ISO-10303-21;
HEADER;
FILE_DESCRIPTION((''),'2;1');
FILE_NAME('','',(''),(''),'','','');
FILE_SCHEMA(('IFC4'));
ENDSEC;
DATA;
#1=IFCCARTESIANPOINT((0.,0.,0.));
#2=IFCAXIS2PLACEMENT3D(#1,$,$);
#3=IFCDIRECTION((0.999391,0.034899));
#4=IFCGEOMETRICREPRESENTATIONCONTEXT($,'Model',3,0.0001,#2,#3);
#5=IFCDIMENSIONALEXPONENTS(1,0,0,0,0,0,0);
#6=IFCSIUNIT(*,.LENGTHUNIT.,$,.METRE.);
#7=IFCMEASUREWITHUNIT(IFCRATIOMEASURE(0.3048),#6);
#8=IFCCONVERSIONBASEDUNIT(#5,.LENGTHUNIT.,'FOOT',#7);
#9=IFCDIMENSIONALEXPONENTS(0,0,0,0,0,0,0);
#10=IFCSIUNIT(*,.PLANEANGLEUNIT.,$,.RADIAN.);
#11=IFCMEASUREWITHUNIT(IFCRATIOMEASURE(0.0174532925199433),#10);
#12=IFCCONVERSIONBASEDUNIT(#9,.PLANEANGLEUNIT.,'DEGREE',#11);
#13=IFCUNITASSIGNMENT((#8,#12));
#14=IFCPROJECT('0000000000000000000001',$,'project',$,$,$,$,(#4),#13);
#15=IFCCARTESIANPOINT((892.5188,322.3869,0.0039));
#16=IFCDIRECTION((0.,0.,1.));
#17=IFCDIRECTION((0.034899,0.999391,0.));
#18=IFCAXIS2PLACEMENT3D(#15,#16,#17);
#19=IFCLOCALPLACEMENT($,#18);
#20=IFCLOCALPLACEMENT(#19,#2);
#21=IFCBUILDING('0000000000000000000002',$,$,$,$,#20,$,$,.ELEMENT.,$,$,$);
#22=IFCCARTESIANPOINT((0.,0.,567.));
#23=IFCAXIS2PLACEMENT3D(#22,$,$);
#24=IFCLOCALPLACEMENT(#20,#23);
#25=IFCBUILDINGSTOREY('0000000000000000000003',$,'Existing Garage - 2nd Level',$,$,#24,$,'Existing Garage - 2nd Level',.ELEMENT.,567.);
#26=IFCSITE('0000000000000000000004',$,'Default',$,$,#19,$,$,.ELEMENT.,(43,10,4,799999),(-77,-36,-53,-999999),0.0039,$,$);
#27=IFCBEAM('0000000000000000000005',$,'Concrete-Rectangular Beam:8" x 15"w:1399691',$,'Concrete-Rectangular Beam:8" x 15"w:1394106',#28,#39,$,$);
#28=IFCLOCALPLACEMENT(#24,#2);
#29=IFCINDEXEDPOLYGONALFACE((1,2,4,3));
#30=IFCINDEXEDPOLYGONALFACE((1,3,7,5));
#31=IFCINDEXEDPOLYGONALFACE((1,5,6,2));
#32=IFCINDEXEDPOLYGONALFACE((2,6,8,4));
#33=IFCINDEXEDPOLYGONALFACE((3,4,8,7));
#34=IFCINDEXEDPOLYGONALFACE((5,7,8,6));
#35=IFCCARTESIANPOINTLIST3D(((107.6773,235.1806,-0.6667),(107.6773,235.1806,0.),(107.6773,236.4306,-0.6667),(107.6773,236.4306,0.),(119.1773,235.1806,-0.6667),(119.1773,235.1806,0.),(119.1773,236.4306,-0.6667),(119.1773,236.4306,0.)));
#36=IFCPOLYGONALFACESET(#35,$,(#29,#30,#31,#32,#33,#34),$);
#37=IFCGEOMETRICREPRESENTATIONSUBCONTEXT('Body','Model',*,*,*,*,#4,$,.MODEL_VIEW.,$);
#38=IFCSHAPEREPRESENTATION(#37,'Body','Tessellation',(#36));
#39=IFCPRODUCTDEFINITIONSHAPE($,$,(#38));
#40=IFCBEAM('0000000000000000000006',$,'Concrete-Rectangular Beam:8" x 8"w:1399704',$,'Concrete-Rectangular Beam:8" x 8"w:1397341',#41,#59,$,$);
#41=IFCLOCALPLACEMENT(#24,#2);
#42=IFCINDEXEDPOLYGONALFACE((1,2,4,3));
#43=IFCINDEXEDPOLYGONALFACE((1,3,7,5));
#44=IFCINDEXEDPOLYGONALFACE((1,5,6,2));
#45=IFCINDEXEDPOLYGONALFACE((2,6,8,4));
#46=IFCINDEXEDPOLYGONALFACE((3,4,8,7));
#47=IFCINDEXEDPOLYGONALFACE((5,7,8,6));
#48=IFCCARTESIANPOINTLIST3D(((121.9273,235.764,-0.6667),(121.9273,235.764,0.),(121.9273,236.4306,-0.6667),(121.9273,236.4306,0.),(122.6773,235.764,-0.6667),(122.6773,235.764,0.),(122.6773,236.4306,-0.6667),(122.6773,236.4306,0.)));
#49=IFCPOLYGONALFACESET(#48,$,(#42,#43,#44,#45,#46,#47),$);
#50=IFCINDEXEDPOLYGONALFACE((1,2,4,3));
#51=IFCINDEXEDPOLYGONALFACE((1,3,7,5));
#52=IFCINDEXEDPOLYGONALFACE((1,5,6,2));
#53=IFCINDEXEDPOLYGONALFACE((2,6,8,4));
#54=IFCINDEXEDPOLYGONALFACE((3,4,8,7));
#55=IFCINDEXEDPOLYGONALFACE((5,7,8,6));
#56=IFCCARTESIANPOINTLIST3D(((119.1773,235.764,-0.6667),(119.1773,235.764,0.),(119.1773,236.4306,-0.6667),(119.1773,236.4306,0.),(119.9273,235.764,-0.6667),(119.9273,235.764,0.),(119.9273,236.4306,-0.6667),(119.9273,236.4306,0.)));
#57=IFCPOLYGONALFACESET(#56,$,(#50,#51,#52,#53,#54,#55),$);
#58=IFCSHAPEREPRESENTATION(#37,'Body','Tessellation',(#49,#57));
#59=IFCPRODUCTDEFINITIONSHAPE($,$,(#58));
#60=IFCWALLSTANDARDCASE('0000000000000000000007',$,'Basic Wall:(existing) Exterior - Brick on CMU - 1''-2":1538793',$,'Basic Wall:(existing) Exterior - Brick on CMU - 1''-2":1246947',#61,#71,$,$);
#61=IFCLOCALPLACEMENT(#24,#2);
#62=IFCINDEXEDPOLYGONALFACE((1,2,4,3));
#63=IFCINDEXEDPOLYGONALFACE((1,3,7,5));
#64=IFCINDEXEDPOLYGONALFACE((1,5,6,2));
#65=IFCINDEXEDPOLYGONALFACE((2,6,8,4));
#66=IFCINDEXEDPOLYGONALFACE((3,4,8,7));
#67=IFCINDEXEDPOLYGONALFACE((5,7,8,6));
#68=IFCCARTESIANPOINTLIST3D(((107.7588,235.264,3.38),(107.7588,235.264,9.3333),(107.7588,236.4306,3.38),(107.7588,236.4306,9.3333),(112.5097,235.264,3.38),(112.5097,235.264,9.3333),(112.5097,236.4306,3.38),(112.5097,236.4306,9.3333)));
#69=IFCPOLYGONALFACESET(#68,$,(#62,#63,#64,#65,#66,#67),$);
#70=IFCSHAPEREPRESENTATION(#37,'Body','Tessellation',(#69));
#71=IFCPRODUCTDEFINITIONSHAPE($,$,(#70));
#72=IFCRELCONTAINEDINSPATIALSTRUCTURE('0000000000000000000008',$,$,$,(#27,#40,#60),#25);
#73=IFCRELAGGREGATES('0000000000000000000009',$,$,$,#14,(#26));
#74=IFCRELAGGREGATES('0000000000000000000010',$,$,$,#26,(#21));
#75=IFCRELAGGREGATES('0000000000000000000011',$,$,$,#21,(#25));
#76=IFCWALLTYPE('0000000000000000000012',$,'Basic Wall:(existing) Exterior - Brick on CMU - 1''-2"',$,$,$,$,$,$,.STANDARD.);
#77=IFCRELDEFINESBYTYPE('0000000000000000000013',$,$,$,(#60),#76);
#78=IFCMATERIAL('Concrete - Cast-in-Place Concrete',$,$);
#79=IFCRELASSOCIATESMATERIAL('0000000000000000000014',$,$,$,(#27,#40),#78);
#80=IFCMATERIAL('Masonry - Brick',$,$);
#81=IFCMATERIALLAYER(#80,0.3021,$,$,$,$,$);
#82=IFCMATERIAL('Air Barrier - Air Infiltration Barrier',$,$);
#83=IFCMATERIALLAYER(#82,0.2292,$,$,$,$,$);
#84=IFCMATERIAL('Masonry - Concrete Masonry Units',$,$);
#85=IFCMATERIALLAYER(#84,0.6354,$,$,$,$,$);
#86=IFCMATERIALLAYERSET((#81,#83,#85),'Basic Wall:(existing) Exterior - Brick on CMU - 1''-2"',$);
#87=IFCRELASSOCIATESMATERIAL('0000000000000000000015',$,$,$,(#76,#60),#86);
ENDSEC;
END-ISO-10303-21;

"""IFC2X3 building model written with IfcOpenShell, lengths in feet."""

from ifc_helpers import new_model, entity, si_unit, converted_unit, direction, frame, frame_2d, origin, place, context, subcontext, project, spatial, rectangle, extrude, material, layer, layer_set, layer_usage, type_object, element, save


model = new_model("IFC2X3")

# Units and contexts
model_context = context("Model", 3, precision=0.0001, world=origin(), true_north=direction((0.999391, 0.034899)))
body_context = subcontext(model_context, "Body", "Model", "MODEL_VIEW")
ifc_project = project(units=[converted_unit("LENGTHUNIT", "FOOT", entity("IfcRatioMeasure", 0.3048), si_unit("LENGTHUNIT", "METRE"), dimensions=[1, 0, 0, 0, 0, 0, 0]), converted_unit("PLANEANGLEUNIT", "DEGREE", entity("IfcRatioMeasure", 0.0174532925199433), si_unit("PLANEANGLEUNIT", "RADIAN"), dimensions=[0, 0, 0, 0, 0, 0, 0])], contexts=[model_context])

# Site, building, storey
site_placement = place(None, frame((892.5188, 322.3869, 0.0039), z_axis=(0.0, 0.0, 1.0), x_axis=(0.034899, 0.999391, 0.0)))
site = spatial("IfcSite", under=ifc_project, at=site_placement, Name="Default", CompositionType="ELEMENT", RefLatitude=(43, 10, 4, 799999), RefLongitude=(-77, -36, -53, -999999), RefElevation=0.0039)
building_placement = place(site_placement, origin())
building = spatial("IfcBuilding", under=site, at=building_placement, CompositionType="ELEMENT")
storey_placement = place(building_placement, frame((0.0, 0.0, 567.0)))
storey = spatial("IfcBuildingStorey", under=building, at=storey_placement, Name="Existing Garage - 2nd Level", LongName="Existing Garage - 2nd Level", CompositionType="ELEMENT", Elevation=567.0)

# Beams
ifc_material_1 = material(Name="Concrete - Cast-in-Place Concrete")
beam_1_placement = place(storey_placement, frame((107.6773, 235.8056, 0.0)))
element("IfcBeam", 1, at=beam_1_placement, inside=storey, material=ifc_material_1, Name="Concrete-Rectangular Beam:8\" x 15\"w:1399691", ObjectType="Concrete-Rectangular Beam:8\" x 15\"w:1394106", context=body_context, shape_type="SweptSolid", body=[
    extrude(rectangle(XDim=0.6667, YDim=1.25, at=frame_2d((0.0, 0.0), x_axis=(1.0, 0.0))), frame((0.0, 0.0, -0.3333), z_axis=(1.0, 0.0, 0.0), x_axis=(0.0, 0.0, -1.0)), (0.0, 0.0, 1.0), 11.5),
])
beam_2_placement = place(storey_placement, frame((119.1773, 236.0973, 0.0)))
element("IfcBeam", 2, at=beam_2_placement, inside=storey, material=ifc_material_1, Name="Concrete-Rectangular Beam:8\" x 8\"w:1399704", ObjectType="Concrete-Rectangular Beam:8\" x 8\"w:1397341", context=body_context, shape_type="SweptSolid", body=[
    extrude(rectangle(XDim=0.6667, YDim=0.6667, at=frame_2d((0.0, 0.0), x_axis=(1.0, 0.0))), frame((2.75, 0.0, -0.3333), z_axis=(1.0, 0.0, 0.0), x_axis=(0.0, 0.0, -1.0)), (0.0, 0.0, 1.0), 0.75),
    extrude(rectangle(XDim=0.6667, YDim=0.6667, at=frame_2d((0.0, 0.0), x_axis=(0.0, 1.0))), frame((0.0, 0.0, -0.3333), z_axis=(1.0, 0.0, 0.0), x_axis=(0.0, -1.0, 0.0)), (0.0, 0.0, 1.0), 0.75),
])

# Wall
ifc_material_2 = material(Name="Masonry - Brick")
ifc_layer_1 = layer(ifc_material_2, 0.3021)
ifc_material_3 = material(Name="Air Barrier - Air Infiltration Barrier")
ifc_layer_2 = layer(ifc_material_3, 0.2292)
ifc_material_4 = material(Name="Masonry - Concrete Masonry Units")
ifc_layer_3 = layer(ifc_material_4, 0.6354)
ifc_layer_set = layer_set([ifc_layer_1, ifc_layer_2, ifc_layer_3], Name="Basic Wall:(existing) Exterior - Brick on CMU - 1'-2\"")
ifc_layer_usage = layer_usage(ifc_layer_set, "AXIS2", "POSITIVE", -0.5833)
wall_type = type_object("IfcWallType", Name="Basic Wall:(existing) Exterior - Brick on CMU - 1'-2\"", PredefinedType="STANDARD", material=ifc_layer_set)
wall_placement = place(storey_placement, frame((107.7588, 235.8473, 3.38)))
element("IfcWallStandardCase", 3, at=wall_placement, inside=storey, type_object=wall_type, material=ifc_layer_usage, Name="Basic Wall:(existing) Exterior - Brick on CMU - 1'-2\":1538793", ObjectType="Basic Wall:(existing) Exterior - Brick on CMU - 1'-2\":1246947", context=body_context, shape_type="SweptSolid", body=[
    extrude(rectangle(XDim=4.7509, YDim=1.1667, at=frame_2d((2.3755, 0.0), x_axis=(-1.0, 0.0))), origin(), (0.0, 0.0, 1.0), 5.9533),
])

save(model, "model.ifc")
